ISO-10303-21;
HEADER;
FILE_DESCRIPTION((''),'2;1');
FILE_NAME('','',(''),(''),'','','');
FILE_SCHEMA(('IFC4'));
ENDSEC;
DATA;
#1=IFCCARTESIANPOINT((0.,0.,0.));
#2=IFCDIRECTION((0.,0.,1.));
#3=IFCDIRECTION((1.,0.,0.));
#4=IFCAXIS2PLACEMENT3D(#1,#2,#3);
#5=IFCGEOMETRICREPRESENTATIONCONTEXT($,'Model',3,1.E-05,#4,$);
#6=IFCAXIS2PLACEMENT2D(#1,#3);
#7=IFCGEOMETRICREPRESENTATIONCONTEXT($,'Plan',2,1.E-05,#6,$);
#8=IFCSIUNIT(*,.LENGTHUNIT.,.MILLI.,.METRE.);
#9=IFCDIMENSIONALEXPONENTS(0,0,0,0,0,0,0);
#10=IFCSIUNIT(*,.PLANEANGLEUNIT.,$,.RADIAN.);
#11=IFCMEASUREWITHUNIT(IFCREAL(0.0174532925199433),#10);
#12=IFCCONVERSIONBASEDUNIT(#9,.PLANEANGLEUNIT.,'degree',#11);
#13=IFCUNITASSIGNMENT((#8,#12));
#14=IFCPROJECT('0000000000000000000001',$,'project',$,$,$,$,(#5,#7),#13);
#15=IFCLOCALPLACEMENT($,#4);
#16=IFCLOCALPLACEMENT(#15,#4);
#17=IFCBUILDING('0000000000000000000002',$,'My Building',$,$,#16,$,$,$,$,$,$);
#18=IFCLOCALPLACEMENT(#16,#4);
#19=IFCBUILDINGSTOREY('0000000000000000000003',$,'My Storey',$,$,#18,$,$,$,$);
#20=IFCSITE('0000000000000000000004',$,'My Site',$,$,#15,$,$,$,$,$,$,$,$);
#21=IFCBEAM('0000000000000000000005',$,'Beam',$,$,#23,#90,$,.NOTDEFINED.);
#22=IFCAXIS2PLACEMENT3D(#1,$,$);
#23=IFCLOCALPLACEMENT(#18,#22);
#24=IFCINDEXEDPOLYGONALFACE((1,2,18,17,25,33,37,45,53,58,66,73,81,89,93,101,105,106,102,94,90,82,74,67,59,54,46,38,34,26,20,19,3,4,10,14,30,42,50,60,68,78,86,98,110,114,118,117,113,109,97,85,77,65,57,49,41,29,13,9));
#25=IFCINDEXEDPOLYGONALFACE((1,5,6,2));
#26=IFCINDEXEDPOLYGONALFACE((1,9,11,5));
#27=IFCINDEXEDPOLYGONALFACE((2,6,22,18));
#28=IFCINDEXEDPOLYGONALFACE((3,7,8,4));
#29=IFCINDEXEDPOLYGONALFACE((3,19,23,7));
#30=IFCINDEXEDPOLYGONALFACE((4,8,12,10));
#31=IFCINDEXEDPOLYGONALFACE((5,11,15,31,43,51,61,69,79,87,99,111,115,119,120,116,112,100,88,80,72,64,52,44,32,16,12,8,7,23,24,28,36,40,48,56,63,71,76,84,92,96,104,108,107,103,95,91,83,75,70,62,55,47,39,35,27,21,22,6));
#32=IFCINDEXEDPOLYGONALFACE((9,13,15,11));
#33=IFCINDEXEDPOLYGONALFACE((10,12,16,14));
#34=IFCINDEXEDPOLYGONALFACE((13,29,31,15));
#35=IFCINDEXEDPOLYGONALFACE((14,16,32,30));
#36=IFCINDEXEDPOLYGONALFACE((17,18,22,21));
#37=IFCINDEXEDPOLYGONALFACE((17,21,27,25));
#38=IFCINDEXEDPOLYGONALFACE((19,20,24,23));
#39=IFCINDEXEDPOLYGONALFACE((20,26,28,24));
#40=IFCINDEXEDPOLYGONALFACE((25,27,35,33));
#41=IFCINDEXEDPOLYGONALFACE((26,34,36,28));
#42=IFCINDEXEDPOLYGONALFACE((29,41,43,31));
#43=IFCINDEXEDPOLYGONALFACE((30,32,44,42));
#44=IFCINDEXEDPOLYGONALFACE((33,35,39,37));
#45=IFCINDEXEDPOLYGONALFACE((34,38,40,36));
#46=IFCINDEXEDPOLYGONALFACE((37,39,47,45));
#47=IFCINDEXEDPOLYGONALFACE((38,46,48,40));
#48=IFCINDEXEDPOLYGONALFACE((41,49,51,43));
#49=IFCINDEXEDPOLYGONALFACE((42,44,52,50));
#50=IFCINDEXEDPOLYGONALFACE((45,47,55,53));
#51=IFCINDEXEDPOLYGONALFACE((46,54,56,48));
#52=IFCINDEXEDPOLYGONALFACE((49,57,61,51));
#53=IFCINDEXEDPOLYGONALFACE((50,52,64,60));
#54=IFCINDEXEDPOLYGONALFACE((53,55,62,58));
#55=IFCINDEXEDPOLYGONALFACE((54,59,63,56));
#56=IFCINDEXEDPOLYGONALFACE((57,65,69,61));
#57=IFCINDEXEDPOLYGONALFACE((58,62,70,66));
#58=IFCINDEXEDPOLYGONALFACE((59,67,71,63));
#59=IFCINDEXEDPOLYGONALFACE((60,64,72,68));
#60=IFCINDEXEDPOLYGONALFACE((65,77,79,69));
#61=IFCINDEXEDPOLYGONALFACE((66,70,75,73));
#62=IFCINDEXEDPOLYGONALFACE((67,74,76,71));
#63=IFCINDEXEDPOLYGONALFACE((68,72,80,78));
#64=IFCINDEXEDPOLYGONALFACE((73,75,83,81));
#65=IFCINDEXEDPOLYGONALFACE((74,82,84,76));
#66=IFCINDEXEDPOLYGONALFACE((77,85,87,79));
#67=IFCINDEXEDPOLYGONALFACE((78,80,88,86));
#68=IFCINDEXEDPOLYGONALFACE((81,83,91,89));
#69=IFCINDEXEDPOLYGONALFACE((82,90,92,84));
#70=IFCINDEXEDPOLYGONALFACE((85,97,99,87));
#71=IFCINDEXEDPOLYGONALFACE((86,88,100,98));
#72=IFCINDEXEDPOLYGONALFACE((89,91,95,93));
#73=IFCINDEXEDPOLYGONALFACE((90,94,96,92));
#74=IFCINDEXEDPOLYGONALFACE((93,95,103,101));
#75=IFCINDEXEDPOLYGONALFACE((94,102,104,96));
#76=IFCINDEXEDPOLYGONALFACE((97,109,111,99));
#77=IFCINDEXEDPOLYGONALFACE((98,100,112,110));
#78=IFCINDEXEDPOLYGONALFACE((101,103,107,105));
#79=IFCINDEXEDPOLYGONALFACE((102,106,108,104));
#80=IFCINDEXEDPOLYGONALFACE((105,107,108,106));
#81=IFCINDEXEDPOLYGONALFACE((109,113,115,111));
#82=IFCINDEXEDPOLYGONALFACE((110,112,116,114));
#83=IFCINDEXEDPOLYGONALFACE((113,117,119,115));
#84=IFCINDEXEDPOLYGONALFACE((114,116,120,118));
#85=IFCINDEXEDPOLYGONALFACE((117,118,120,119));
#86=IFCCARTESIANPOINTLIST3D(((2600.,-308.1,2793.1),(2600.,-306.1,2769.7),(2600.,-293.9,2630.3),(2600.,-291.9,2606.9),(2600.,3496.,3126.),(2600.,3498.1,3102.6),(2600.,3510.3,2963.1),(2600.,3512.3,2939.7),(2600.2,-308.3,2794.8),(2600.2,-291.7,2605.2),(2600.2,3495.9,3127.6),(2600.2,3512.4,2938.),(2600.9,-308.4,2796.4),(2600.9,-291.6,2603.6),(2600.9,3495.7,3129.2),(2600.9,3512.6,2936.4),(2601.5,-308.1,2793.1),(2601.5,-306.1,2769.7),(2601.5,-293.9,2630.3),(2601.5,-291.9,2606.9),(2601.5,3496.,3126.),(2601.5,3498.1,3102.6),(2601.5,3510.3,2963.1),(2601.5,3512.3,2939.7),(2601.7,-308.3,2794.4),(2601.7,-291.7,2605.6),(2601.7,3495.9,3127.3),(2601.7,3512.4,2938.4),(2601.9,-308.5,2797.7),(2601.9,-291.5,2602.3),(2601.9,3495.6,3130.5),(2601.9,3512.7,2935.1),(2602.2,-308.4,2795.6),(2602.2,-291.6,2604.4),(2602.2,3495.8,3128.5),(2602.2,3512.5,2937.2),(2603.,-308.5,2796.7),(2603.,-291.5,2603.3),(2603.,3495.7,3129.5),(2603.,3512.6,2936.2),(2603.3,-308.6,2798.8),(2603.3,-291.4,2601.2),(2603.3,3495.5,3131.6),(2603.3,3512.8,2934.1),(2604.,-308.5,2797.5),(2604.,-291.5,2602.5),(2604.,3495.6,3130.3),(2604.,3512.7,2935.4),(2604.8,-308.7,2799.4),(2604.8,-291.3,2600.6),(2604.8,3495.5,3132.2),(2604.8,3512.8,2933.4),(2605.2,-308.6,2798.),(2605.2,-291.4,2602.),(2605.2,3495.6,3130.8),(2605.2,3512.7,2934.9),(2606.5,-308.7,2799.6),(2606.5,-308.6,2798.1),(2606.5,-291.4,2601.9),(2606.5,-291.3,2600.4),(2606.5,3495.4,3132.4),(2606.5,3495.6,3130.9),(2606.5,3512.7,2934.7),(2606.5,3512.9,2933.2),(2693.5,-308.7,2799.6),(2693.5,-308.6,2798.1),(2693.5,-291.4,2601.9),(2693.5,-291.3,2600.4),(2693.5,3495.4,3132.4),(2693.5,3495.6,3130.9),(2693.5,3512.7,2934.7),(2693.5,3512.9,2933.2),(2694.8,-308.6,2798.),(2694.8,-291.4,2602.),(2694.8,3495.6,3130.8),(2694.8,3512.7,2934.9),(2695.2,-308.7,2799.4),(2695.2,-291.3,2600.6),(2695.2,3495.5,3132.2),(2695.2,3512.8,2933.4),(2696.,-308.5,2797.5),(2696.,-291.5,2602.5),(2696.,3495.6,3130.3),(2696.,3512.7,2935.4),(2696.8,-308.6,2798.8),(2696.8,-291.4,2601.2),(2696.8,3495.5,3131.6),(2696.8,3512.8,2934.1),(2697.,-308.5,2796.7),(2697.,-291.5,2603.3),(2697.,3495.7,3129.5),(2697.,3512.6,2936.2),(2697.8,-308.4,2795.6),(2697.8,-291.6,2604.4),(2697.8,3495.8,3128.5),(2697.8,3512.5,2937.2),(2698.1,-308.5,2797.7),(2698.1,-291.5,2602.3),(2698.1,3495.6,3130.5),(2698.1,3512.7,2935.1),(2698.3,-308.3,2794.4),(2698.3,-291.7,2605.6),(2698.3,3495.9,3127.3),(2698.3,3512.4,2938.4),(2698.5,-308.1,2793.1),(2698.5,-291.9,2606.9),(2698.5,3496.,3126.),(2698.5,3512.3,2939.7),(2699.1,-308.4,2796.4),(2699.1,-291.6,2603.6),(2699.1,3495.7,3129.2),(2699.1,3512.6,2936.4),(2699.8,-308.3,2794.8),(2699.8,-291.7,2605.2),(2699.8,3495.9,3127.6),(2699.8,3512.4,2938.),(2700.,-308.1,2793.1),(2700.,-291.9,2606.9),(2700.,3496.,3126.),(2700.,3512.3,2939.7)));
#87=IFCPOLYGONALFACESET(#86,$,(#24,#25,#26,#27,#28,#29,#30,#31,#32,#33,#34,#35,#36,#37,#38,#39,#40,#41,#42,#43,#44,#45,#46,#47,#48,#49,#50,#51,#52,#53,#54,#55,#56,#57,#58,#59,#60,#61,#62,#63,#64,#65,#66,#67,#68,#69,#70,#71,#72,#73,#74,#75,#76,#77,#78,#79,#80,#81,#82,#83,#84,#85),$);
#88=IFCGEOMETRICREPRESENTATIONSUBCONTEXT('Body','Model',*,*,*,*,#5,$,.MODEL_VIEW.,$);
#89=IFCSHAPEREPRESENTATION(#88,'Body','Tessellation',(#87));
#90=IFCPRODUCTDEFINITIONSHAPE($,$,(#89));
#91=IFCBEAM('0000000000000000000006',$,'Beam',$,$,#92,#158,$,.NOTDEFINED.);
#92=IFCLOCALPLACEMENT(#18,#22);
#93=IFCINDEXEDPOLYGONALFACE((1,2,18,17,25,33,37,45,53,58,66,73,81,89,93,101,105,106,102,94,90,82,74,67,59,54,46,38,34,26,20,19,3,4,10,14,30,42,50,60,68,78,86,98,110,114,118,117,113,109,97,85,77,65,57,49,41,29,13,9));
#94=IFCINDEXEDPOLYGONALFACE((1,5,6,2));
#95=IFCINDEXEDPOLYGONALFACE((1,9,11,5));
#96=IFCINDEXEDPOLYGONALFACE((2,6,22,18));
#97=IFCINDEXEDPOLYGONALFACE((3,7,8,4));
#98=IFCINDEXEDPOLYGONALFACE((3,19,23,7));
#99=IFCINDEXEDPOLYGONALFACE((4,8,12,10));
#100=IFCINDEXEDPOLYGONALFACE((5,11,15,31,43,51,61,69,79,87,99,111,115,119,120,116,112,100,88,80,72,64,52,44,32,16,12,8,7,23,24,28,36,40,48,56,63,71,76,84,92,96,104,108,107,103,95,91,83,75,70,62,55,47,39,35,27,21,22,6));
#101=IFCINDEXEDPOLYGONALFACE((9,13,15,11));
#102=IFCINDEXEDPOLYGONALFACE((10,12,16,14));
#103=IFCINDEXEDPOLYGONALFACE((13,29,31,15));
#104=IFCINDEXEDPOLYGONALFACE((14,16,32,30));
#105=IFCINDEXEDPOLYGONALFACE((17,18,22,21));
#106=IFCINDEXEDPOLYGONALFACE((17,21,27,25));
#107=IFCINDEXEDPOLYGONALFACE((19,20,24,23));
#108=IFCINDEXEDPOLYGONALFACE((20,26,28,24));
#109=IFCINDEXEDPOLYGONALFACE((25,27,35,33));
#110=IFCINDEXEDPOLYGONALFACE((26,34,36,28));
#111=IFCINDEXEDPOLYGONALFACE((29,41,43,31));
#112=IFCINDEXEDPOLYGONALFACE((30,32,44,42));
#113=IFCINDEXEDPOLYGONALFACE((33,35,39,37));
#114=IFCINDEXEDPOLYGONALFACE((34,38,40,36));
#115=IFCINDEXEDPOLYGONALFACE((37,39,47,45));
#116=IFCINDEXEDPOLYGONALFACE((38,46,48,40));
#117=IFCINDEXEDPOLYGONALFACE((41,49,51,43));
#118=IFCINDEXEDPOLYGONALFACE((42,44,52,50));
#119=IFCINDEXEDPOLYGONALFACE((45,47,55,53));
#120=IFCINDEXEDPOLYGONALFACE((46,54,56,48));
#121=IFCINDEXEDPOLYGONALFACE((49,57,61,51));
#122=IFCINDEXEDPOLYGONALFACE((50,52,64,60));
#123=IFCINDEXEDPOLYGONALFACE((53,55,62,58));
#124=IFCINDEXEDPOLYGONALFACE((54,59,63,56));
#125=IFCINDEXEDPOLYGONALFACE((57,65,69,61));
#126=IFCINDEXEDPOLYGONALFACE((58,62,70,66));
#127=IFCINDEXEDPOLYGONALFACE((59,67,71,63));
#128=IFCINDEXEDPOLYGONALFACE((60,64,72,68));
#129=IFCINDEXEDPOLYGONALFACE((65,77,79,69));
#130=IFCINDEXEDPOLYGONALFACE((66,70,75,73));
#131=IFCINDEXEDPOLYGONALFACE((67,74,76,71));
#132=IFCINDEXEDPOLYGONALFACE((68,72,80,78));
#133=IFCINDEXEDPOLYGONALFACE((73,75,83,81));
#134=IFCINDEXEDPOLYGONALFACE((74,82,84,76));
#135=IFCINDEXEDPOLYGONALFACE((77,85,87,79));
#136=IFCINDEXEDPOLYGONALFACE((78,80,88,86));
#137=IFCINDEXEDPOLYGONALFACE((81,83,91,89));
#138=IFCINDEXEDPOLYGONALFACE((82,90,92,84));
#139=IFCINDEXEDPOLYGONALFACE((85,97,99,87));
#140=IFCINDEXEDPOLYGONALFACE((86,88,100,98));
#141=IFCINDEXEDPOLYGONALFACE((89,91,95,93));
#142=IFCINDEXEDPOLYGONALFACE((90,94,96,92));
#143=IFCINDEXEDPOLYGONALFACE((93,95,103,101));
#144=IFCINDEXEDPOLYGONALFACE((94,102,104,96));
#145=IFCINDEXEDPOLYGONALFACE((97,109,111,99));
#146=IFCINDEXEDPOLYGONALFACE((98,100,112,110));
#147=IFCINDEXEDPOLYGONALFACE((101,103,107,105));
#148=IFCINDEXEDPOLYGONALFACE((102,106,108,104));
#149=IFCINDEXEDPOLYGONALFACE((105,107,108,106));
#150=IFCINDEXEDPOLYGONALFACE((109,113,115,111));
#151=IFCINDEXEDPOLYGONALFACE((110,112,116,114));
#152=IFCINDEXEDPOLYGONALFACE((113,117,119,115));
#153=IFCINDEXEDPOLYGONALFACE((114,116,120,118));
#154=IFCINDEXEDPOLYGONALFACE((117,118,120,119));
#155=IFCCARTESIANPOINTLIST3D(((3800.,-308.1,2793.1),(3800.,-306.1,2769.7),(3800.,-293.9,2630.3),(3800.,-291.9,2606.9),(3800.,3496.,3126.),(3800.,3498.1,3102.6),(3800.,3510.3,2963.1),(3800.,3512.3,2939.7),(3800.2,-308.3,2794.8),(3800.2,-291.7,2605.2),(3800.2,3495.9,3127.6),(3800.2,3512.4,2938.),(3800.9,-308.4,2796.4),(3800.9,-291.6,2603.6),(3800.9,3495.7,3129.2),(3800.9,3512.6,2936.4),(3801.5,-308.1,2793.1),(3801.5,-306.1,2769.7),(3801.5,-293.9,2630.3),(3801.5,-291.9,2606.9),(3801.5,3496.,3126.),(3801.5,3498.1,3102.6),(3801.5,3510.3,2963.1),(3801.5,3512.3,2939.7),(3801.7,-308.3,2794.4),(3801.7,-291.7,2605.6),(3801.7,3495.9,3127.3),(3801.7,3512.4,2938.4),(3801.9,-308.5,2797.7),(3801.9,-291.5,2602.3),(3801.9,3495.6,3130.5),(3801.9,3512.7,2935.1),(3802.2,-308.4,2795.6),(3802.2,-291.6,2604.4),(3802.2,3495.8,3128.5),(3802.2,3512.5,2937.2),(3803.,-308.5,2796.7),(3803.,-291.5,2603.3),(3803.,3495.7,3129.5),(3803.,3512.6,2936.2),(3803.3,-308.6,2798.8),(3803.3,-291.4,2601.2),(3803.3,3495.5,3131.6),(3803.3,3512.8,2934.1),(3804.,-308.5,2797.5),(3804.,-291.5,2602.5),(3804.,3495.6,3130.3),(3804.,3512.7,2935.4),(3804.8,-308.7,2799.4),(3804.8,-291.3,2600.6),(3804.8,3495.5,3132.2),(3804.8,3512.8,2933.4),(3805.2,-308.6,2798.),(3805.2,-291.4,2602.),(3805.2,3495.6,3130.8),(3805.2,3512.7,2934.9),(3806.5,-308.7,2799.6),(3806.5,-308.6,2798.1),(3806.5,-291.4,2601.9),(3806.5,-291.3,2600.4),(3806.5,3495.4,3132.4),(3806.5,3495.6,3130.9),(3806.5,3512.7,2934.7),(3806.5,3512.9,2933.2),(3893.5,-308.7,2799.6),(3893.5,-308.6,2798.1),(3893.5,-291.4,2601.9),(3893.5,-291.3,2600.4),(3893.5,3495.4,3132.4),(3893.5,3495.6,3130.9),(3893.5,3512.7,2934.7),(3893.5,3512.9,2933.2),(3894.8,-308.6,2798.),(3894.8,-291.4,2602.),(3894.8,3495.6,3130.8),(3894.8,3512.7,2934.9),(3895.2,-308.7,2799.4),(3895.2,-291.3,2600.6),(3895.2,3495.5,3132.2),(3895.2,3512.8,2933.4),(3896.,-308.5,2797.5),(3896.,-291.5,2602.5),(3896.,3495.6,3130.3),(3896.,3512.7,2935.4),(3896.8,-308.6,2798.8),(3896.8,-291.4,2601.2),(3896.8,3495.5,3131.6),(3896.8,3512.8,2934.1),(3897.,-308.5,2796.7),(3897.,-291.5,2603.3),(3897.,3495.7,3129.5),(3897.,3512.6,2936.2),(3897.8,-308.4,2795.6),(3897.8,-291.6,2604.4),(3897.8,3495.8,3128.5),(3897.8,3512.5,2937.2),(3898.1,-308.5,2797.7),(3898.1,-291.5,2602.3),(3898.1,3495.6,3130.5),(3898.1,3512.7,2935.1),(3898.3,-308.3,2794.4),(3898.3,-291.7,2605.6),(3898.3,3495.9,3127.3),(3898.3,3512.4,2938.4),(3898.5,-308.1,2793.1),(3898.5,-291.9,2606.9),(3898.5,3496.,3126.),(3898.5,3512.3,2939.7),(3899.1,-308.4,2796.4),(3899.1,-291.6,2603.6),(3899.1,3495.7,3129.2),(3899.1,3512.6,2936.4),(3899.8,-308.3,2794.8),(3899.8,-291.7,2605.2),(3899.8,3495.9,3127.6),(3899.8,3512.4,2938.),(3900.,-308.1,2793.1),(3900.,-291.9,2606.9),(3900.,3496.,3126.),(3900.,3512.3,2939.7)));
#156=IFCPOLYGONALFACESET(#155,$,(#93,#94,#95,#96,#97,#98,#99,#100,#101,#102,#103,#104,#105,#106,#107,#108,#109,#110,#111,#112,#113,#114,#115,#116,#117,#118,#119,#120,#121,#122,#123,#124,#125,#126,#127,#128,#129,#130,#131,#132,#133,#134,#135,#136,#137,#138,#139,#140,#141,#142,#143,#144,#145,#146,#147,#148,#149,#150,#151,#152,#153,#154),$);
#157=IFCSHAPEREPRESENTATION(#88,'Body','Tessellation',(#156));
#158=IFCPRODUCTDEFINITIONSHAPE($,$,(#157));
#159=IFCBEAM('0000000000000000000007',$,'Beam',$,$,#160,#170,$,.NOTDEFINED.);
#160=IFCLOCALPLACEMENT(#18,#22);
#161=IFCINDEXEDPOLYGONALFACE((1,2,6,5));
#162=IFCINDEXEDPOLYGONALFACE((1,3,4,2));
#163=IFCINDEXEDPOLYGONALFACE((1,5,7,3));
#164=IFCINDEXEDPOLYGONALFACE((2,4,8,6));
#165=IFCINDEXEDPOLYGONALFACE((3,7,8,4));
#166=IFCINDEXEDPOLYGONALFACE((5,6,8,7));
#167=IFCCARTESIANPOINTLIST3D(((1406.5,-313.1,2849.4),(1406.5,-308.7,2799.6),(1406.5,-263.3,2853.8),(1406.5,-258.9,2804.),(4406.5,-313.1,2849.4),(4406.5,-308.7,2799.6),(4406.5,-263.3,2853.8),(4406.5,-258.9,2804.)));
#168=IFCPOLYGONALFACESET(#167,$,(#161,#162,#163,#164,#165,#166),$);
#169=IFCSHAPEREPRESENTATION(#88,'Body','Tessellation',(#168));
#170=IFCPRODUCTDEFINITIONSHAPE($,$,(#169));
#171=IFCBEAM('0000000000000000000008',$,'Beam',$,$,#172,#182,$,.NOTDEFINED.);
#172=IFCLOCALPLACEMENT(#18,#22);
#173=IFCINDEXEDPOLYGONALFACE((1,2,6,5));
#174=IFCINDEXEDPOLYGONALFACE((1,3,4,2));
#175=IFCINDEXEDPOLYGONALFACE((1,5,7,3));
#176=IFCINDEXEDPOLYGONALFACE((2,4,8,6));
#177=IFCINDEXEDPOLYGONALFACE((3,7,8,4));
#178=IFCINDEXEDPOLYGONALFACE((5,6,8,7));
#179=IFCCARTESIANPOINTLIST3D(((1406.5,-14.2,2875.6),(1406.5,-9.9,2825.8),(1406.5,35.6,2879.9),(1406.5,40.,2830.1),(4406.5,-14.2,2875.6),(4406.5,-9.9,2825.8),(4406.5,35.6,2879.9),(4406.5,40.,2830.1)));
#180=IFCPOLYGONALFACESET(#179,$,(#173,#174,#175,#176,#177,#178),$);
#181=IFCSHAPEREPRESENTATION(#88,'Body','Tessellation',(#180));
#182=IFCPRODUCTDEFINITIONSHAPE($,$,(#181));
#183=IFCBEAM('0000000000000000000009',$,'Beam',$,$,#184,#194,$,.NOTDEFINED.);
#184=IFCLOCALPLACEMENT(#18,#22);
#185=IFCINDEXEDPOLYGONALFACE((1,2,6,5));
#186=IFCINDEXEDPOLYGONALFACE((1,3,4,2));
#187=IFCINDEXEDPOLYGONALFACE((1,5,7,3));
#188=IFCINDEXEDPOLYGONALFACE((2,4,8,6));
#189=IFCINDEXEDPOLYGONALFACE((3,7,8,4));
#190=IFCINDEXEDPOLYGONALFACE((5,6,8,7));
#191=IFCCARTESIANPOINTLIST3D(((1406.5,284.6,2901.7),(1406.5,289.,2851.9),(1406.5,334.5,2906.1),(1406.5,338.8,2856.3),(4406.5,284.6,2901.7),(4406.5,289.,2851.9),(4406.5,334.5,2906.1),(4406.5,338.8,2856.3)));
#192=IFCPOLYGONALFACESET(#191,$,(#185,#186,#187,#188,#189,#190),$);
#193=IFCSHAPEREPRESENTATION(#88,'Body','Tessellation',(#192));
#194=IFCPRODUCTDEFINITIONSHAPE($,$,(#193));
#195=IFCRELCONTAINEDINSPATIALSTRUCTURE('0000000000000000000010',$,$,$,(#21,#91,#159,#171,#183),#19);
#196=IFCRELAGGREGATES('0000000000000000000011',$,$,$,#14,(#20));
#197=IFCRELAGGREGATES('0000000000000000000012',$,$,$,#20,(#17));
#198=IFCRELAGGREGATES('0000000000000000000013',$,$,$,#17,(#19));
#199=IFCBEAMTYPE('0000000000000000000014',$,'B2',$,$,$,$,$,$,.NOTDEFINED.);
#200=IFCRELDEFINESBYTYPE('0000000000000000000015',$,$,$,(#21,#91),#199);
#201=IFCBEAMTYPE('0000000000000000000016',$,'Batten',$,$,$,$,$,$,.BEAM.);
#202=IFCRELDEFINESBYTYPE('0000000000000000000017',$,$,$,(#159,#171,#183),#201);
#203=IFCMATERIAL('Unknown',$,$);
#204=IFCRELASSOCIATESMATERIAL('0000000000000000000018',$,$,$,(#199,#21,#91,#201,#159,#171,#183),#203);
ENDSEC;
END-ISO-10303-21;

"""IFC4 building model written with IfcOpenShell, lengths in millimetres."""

from ifc_helpers import new_model, entity, si_unit, converted_unit, frame, frame_2d, origin_with_axes, place, context, subcontext, project, spatial, rectangle, c_section, extrude, material, material_profile, profile_set, profile_usage, type_object, element, save


model = new_model("IFC4")

# Units and contexts
model_context = context("Model", 3, precision=1e-05, world=origin_with_axes())
plan_context = context("Plan", 2, precision=1e-05, world=frame_2d((0.0, 0.0, 0.0), x_axis=(1.0, 0.0, 0.0)))
body_context = subcontext(model_context, "Body", "Model", "MODEL_VIEW")
ifc_project = project(units=[si_unit("LENGTHUNIT", "METRE", prefix="MILLI"), converted_unit("PLANEANGLEUNIT", "degree", entity("IfcReal", 0.0174532925199433), si_unit("PLANEANGLEUNIT", "RADIAN"), dimensions=[0, 0, 0, 0, 0, 0, 0])], contexts=[model_context, plan_context])

# Site, building, storey
site_placement = place(None, origin_with_axes())
site = spatial("IfcSite", under=ifc_project, at=site_placement, Name="My Site")
building_placement = place(site_placement, origin_with_axes())
building = spatial("IfcBuilding", under=site, at=building_placement, Name="My Building")
storey_placement = place(building_placement, origin_with_axes())
storey = spatial("IfcBuildingStorey", under=building, at=storey_placement, Name="My Storey")

# Shared definitions
ifc_material = material(Name="Unknown")

# Beams
ifc_material_profile_1 = material_profile(ifc_material, c_section(Depth=200.0, Width=100.0, WallThickness=1.5, Girth=30.0, InternalFilletRadius=5.0))
ifc_profile_set_1 = profile_set([ifc_material_profile_1])
beam_type_1 = type_object("IfcBeamType", Name="B2", PredefinedType="NOTDEFINED", material=ifc_profile_set_1)
ifc_profile_usage_1 = profile_usage(ifc_profile_set_1, cardinal=5)
beam_1_placement = place(storey_placement, frame((2650.0, -300.0, 2700.0), z_axis=(0.0, 0.996195, 0.087156), x_axis=(-1.0, 0.0, 0.0)))
element("IfcBeam", 1, at=beam_1_placement, inside=storey, type_object=beam_type_1, material=ifc_profile_usage_1, Name="Beam", PredefinedType="NOTDEFINED", context=body_context, shape_type="SweptSolid", body=[
    extrude(c_section(Depth=200.0, Width=100.0, WallThickness=1.5, Girth=30.0, InternalFilletRadius=5.0), origin_with_axes(), (0.0, 0.0, 1.0), 3818.7),
])
ifc_profile_usage_2 = profile_usage(ifc_profile_set_1, cardinal=5)
beam_2_placement = place(storey_placement, frame((3850.0, -300.0, 2700.0), z_axis=(0.0, 0.996195, 0.087156), x_axis=(-1.0, 0.0, 0.0)))
element("IfcBeam", 2, at=beam_2_placement, inside=storey, type_object=beam_type_1, material=ifc_profile_usage_2, Name="Beam", PredefinedType="NOTDEFINED", context=body_context, shape_type="SweptSolid", body=[
    extrude(c_section(Depth=200.0, Width=100.0, WallThickness=1.5, Girth=30.0, InternalFilletRadius=5.0), origin_with_axes(), (0.0, 0.0, 1.0), 3818.7),
])
ifc_material_profile_2 = material_profile(ifc_material, rectangle(XDim=50.0, YDim=50.0))
ifc_profile_set_2 = profile_set([ifc_material_profile_2], Name="blank")
ifc_profile_usage_3 = profile_usage(ifc_profile_set_2, cardinal=5)
beam_type_2 = type_object("IfcBeamType", Name="Batten", PredefinedType="BEAM", material=ifc_profile_set_2)
beam_3_placement = place(storey_placement, frame((1406.5, -286.0, 2826.7), z_axis=(1.0, 0.0, 0.0), x_axis=(0.0, 0.996195, 0.087156)))
element("IfcBeam", 3, at=beam_3_placement, inside=storey, type_object=beam_type_2, material=ifc_profile_usage_3, Name="Beam", PredefinedType="NOTDEFINED", context=body_context, shape_type="SweptSolid", body=[
    extrude(rectangle(XDim=50.0, YDim=50.0), origin_with_axes(), (0.0, 0.0, 1.0), 3000.0),
])
ifc_profile_usage_4 = profile_usage(ifc_profile_set_2, cardinal=5)
beam_4_placement = place(storey_placement, frame((1406.5, 12.9, 2852.8), z_axis=(1.0, 0.0, 0.0), x_axis=(0.0, 0.996195, 0.087156)))
element("IfcBeam", 4, at=beam_4_placement, inside=storey, type_object=beam_type_2, material=ifc_profile_usage_4, Name="Beam", PredefinedType="NOTDEFINED", context=body_context, shape_type="SweptSolid", body=[
    extrude(rectangle(XDim=50.0, YDim=50.0), origin_with_axes(), (0.0, 0.0, 1.0), 3000.0),
])
ifc_profile_usage_5 = profile_usage(ifc_profile_set_2, cardinal=5)
beam_5_placement = place(storey_placement, frame((1406.5, 311.7, 2879.0), z_axis=(1.0, 0.0, 0.0), x_axis=(0.0, 0.996195, 0.087156)))
element("IfcBeam", 5, at=beam_5_placement, inside=storey, type_object=beam_type_2, material=ifc_profile_usage_5, Name="Beam", PredefinedType="NOTDEFINED", context=body_context, shape_type="SweptSolid", body=[
    extrude(rectangle(XDim=50.0, YDim=50.0), origin_with_axes(), (0.0, 0.0, 1.0), 3000.0),
])

save(model, "model.ifc")
